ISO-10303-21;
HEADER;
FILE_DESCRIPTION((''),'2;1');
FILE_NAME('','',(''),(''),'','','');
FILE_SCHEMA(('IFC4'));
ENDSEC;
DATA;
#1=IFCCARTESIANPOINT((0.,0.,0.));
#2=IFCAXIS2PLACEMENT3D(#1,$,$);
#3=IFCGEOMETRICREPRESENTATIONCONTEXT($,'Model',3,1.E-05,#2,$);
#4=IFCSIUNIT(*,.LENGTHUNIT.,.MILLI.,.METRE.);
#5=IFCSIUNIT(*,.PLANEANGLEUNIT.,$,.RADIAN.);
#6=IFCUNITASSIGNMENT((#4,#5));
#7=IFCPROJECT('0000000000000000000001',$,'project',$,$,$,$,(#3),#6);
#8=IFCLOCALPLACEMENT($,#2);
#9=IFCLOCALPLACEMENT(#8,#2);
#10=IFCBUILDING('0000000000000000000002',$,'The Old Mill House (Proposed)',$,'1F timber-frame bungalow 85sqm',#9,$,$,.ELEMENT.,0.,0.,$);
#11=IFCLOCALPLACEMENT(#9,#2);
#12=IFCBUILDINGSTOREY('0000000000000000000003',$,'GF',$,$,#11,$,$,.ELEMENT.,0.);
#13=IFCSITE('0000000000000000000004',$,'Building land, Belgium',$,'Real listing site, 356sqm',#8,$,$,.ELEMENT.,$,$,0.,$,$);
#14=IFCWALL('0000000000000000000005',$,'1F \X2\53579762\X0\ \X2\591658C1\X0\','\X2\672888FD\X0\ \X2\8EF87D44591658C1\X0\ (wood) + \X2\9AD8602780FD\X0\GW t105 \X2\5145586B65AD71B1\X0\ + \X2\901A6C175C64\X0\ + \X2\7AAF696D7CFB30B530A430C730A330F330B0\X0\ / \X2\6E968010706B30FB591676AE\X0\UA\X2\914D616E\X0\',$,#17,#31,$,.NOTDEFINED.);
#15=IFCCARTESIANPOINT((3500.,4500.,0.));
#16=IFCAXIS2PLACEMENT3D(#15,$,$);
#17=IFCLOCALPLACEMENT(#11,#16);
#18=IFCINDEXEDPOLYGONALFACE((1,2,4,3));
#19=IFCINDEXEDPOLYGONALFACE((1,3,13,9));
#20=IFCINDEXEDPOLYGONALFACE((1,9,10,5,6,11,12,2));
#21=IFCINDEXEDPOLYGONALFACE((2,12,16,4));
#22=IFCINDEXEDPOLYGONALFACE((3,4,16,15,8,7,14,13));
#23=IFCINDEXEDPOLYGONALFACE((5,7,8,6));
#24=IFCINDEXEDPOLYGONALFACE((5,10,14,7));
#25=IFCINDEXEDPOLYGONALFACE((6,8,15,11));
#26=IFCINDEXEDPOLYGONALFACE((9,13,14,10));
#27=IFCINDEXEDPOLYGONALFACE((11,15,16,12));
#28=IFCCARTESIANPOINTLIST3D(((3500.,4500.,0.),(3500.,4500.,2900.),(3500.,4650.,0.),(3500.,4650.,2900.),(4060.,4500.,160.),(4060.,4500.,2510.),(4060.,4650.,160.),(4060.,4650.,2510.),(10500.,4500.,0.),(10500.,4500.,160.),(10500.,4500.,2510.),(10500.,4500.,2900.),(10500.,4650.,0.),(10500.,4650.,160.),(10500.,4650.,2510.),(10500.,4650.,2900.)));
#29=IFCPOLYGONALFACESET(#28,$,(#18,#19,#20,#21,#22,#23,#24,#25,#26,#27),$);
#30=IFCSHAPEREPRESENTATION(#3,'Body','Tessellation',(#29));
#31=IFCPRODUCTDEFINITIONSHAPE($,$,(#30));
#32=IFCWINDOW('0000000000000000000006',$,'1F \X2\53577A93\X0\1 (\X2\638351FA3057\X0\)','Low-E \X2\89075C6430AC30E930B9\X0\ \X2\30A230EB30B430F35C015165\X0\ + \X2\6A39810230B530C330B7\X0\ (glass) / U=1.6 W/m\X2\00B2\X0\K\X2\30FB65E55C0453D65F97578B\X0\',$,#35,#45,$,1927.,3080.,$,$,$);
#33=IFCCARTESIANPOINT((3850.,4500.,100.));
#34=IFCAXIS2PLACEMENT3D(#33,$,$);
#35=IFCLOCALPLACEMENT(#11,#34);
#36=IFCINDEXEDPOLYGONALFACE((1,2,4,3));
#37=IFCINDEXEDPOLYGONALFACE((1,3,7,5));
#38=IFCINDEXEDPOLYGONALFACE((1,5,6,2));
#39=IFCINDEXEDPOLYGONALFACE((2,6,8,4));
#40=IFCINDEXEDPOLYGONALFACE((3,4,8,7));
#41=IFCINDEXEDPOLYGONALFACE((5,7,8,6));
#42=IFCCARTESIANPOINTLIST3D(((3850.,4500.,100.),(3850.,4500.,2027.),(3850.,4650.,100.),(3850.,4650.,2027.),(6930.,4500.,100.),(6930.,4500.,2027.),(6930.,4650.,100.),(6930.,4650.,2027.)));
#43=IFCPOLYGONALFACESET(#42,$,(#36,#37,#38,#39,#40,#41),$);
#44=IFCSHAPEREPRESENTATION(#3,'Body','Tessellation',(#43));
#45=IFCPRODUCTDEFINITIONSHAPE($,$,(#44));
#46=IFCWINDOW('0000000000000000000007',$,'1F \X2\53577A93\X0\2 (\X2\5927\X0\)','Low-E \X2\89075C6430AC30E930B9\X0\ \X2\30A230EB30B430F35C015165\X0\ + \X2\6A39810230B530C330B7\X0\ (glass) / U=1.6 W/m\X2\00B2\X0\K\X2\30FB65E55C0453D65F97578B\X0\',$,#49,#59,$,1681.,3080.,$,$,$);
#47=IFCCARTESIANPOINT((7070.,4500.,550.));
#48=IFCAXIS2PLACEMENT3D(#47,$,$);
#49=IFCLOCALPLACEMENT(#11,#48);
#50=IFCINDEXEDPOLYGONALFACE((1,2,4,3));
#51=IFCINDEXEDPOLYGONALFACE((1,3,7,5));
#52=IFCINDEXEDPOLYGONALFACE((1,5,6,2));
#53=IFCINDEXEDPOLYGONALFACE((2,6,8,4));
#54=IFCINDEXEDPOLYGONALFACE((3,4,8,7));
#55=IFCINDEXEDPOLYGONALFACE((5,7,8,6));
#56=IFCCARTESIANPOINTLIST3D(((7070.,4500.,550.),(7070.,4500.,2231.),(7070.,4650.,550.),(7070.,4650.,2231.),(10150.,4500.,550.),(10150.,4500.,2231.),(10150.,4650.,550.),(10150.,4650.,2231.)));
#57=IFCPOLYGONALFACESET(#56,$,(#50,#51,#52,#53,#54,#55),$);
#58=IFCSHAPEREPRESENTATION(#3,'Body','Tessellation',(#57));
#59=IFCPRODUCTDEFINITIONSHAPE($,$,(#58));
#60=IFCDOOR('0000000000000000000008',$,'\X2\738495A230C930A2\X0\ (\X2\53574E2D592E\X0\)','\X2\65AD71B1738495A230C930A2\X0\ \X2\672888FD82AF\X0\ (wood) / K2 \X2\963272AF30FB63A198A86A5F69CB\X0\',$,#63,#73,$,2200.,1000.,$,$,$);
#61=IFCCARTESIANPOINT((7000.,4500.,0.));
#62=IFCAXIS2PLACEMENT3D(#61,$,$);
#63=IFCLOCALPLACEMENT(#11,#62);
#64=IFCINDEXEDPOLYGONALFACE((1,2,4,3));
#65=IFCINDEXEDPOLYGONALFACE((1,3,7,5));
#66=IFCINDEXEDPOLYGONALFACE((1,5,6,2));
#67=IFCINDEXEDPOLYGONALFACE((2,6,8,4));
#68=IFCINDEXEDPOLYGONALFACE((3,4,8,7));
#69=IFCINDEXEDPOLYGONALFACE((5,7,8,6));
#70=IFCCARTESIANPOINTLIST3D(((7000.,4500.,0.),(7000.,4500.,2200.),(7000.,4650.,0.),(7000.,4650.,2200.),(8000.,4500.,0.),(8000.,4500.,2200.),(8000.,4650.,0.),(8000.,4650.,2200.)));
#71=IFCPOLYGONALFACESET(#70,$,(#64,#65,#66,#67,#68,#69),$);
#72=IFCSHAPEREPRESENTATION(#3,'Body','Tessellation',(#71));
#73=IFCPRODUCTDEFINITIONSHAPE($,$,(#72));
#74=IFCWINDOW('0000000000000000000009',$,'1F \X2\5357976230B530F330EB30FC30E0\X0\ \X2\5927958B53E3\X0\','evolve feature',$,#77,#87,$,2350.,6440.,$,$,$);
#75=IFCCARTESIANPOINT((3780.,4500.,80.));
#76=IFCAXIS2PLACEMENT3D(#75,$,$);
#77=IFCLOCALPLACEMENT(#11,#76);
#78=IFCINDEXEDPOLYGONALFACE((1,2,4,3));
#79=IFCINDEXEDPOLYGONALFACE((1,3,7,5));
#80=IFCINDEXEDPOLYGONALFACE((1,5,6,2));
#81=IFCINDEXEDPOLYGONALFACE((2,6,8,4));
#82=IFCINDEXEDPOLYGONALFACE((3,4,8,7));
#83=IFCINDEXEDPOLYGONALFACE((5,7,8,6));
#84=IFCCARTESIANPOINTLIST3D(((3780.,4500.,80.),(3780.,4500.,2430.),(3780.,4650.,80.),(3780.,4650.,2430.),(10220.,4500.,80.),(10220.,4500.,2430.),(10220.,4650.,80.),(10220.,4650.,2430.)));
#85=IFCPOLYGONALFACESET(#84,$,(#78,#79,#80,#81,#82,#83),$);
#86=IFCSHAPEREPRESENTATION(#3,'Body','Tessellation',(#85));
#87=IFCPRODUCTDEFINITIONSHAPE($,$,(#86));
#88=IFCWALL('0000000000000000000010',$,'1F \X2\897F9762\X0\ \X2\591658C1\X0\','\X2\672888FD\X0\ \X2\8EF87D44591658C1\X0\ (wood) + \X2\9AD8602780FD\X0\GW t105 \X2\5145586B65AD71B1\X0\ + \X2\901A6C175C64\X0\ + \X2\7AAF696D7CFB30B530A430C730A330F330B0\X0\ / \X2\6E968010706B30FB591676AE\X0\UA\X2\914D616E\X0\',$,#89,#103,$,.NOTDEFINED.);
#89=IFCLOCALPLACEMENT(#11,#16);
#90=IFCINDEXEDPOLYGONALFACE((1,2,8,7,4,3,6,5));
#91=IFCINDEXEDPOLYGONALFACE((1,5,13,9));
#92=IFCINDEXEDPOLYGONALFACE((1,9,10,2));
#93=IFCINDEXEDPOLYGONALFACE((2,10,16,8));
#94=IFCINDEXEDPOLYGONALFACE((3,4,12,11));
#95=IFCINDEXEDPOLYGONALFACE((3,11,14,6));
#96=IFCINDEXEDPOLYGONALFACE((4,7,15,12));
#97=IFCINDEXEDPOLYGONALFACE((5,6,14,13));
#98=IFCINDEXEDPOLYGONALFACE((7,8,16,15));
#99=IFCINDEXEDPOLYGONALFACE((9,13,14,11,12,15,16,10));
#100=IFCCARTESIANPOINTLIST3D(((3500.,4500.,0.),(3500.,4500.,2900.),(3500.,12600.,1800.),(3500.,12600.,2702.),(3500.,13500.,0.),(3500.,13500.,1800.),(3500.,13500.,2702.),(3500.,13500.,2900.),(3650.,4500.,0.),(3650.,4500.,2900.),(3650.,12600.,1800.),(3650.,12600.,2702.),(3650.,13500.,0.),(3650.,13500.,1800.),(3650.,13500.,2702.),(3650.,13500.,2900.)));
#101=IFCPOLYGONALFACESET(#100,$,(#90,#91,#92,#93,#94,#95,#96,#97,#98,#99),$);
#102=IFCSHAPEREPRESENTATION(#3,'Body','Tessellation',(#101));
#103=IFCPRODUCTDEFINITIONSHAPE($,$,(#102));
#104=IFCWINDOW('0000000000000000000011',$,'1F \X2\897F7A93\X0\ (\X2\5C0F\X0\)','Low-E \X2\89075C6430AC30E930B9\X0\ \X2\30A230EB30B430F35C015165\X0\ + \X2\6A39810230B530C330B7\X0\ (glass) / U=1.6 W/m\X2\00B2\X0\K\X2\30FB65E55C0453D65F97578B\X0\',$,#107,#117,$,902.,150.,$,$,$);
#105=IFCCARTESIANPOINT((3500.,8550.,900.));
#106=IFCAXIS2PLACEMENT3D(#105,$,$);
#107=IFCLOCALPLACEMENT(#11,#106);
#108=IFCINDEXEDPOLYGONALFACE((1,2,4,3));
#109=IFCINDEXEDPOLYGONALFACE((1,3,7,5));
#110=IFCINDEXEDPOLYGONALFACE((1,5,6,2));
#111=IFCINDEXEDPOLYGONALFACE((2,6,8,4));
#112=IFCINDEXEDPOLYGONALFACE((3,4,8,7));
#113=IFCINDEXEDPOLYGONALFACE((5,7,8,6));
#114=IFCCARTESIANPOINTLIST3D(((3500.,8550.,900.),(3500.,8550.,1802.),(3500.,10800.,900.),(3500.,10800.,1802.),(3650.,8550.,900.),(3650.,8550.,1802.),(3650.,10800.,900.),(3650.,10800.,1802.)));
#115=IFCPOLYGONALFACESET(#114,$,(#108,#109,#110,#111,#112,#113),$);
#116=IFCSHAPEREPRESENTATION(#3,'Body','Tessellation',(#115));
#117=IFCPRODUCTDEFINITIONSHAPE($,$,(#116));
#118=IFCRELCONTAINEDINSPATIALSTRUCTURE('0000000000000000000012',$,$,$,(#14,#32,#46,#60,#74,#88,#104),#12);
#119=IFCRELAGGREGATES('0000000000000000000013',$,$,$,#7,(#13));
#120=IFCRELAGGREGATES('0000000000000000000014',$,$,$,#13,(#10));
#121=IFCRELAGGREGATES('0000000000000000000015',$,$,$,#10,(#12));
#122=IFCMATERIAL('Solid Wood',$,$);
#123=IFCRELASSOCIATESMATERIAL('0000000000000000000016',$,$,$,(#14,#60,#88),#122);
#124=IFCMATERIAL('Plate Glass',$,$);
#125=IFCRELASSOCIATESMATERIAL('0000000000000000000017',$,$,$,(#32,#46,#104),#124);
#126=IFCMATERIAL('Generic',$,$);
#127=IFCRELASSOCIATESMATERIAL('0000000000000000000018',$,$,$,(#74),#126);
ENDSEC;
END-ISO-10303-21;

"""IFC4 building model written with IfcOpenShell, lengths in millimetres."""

from ifc_helpers import new_model, si_unit, frame, frame_2d, origin, place, context, project, spatial, rectangle, extrude, material, element, fill, save


model = new_model("IFC4")

# Units and contexts
model_context = context("Model", 3, precision=1e-05, world=origin())
ifc_project = project(units=[si_unit("LENGTHUNIT", "METRE", prefix="MILLI"), si_unit("PLANEANGLEUNIT", "RADIAN")], contexts=[model_context])

# Site, building, storey
site_placement = place(None, origin())
site = spatial("IfcSite", under=ifc_project, at=site_placement, Name="Building land, Belgium", ObjectType="Real listing site, 356sqm", CompositionType="ELEMENT", RefElevation=0.0)
building_placement = place(site_placement, origin())
building = spatial("IfcBuilding", under=site, at=building_placement, Name="The Old Mill House (Proposed)", ObjectType="1F timber-frame bungalow 85sqm", CompositionType="ELEMENT", ElevationOfRefHeight=0.0, ElevationOfTerrain=0.0)
storey_placement = place(building_placement, origin())
storey = spatial("IfcBuildingStorey", under=building, at=storey_placement, Name="GF", CompositionType="ELEMENT", Elevation=0.0)

# Shared definitions
ifc_material_1 = material(Name="Solid Wood")
ifc_material_2 = material(Name="Generic")

# Wall, openings, windows, door
wall_1_placement = place(storey_placement, frame((3500.0, 4500.0, 0.0)))
wall_1 = element("IfcWall", 1, at=wall_1_placement, inside=storey, material=ifc_material_1, Name="1F 南面 外壁", Description="木製 軸組外壁 (wood) + 高性能GW t105 充填断熱 + 通気層 + 窯業系サイディング / 準耐火・外皮UA配慮", PredefinedType="NOTDEFINED", context=model_context, shape_type="SweptSolid", body=[
    extrude(rectangle(XDim=7000.0, YDim=150.0, at=frame_2d((3500.0, 75.0))), frame((3500.0, 4500.0, 0.0)), (0.0, 0.0, 1.0), 2900.0),
])
opening_1_placement = place(storey_placement, frame((3850.0, 4500.0, 100.0)))
opening_1 = element("IfcOpeningElement", 2, at=opening_1_placement, cuts=wall_1, PredefinedType="NOTDEFINED", context=model_context, shape_type="SweptSolid", body=[
    extrude(rectangle(XDim=3080.0, YDim=150.0, at=frame_2d((1540.0, 75.0))), frame((3850.0, 4500.0, 100.0)), (0.0, 0.0, 1.0), 1927.0),
])
opening_2_placement = place(storey_placement, frame((7070.0, 4500.0, 550.0)))
opening_2 = element("IfcOpeningElement", 3, at=opening_2_placement, cuts=wall_1, PredefinedType="NOTDEFINED", context=model_context, shape_type="SweptSolid", body=[
    extrude(rectangle(XDim=3080.0, YDim=150.0, at=frame_2d((1540.0, 75.0))), frame((7070.0, 4500.0, 550.0)), (0.0, 0.0, 1.0), 1681.0),
])
opening_3_placement = place(storey_placement, frame((7000.0, 4500.0, 0.0)))
opening_3 = element("IfcOpeningElement", 4, at=opening_3_placement, cuts=wall_1, PredefinedType="NOTDEFINED", context=model_context, shape_type="SweptSolid", body=[
    extrude(rectangle(XDim=1000.0, YDim=150.0, at=frame_2d((500.0, 75.0))), frame((7000.0, 4500.0, 0.0)), (0.0, 0.0, 1.0), 2200.0),
])
opening_4_placement = place(storey_placement, frame((3780.0, 4500.0, 80.0)))
opening_4 = element("IfcOpeningElement", 5, at=opening_4_placement, cuts=wall_1, PredefinedType="NOTDEFINED", context=model_context, shape_type="SweptSolid", body=[
    extrude(rectangle(XDim=6440.0, YDim=150.0, at=frame_2d((3220.0, 75.0))), frame((3780.0, 4500.0, 80.0)), (0.0, 0.0, 1.0), 2350.0),
])
ifc_material_3 = material(Name="Plate Glass")
window_1_placement = place(storey_placement, frame((3850.0, 4500.0, 100.0)))
window_1 = element("IfcWindow", 6, at=window_1_placement, inside=storey, material=ifc_material_3, Name="1F 南窓1 (掃出し)", Description="Low-E 複層ガラス アルゴン封入 + 樹脂サッシ (glass) / U=1.6 W/m²K・日射取得型", OverallHeight=1927.0, OverallWidth=3080.0, context=model_context, shape_type="SweptSolid", body=[
    extrude(rectangle(XDim=3080.0, YDim=150.0, at=frame_2d((1540.0, 75.0))), frame((3850.0, 4500.0, 100.0)), (0.0, 0.0, 1.0), 1927.0),
])
fill(opening_1, window_1)
window_2_placement = place(storey_placement, frame((7070.0, 4500.0, 550.0)))
window_2 = element("IfcWindow", 7, at=window_2_placement, inside=storey, material=ifc_material_3, Name="1F 南窓2 (大)", Description="Low-E 複層ガラス アルゴン封入 + 樹脂サッシ (glass) / U=1.6 W/m²K・日射取得型", OverallHeight=1681.0, OverallWidth=3080.0, context=model_context, shape_type="SweptSolid", body=[
    extrude(rectangle(XDim=3080.0, YDim=150.0, at=frame_2d((1540.0, 75.0))), frame((7070.0, 4500.0, 550.0)), (0.0, 0.0, 1.0), 1681.0),
])
fill(opening_2, window_2)
door_placement = place(storey_placement, frame((7000.0, 4500.0, 0.0)))
door = element("IfcDoor", 8, at=door_placement, inside=storey, material=ifc_material_1, Name="玄関ドア (南中央)", Description="断熱玄関ドア 木製芯 (wood) / K2 防犯・採風機構", OverallHeight=2200.0, OverallWidth=1000.0, context=model_context, shape_type="SweptSolid", body=[
    extrude(rectangle(XDim=1000.0, YDim=150.0, at=frame_2d((500.0, 75.0))), frame((7000.0, 4500.0, 0.0)), (0.0, 0.0, 1.0), 2200.0),
])
fill(opening_3, door)
window_3_placement = place(storey_placement, frame((3780.0, 4500.0, 80.0)))
window_3 = element("IfcWindow", 9, at=window_3_placement, inside=storey, material=ifc_material_2, Name="1F 南面サンルーム 大開口", Description="evolve feature", OverallHeight=2350.0, OverallWidth=6440.0, context=model_context, shape_type="SweptSolid", body=[
    extrude(rectangle(XDim=6440.0, YDim=150.0, at=frame_2d((3220.0, 75.0))), frame((3780.0, 4500.0, 80.0)), (0.0, 0.0, 1.0), 2350.0),
])
fill(opening_4, window_3)

# Wall, opening, window
wall_2_placement = place(storey_placement, frame((3500.0, 4500.0, 0.0)))
wall_2 = element("IfcWall", 10, at=wall_2_placement, inside=storey, material=ifc_material_1, Name="1F 西面 外壁", Description="木製 軸組外壁 (wood) + 高性能GW t105 充填断熱 + 通気層 + 窯業系サイディング / 準耐火・外皮UA配慮", PredefinedType="NOTDEFINED", context=model_context, shape_type="SweptSolid", body=[
    extrude(rectangle(XDim=150.0, YDim=9000.0, at=frame_2d((75.0, 4500.0))), frame((3500.0, 4500.0, 0.0)), (0.0, 0.0, 1.0), 2900.0),
])
opening_5_placement = place(storey_placement, frame((3500.0, 8550.0, 900.0)))
opening_5 = element("IfcOpeningElement", 11, at=opening_5_placement, cuts=wall_2, PredefinedType="NOTDEFINED", context=model_context, shape_type="SweptSolid", body=[
    extrude(rectangle(XDim=150.0, YDim=2250.0, at=frame_2d((75.0, 1125.0))), frame((3500.0, 8550.0, 900.0)), (0.0, 0.0, 1.0), 902.0),
])
window_4_placement = place(storey_placement, frame((3500.0, 8550.0, 900.0)))
window_4 = element("IfcWindow", 12, at=window_4_placement, inside=storey, material=ifc_material_3, Name="1F 西窓 (小)", Description="Low-E 複層ガラス アルゴン封入 + 樹脂サッシ (glass) / U=1.6 W/m²K・日射取得型", OverallHeight=902.0, OverallWidth=150.0, context=model_context, shape_type="SweptSolid", body=[
    extrude(rectangle(XDim=150.0, YDim=2250.0, at=frame_2d((75.0, 1125.0))), frame((3500.0, 8550.0, 900.0)), (0.0, 0.0, 1.0), 902.0),
])
fill(opening_5, window_4)

save(model, "model.ifc")
